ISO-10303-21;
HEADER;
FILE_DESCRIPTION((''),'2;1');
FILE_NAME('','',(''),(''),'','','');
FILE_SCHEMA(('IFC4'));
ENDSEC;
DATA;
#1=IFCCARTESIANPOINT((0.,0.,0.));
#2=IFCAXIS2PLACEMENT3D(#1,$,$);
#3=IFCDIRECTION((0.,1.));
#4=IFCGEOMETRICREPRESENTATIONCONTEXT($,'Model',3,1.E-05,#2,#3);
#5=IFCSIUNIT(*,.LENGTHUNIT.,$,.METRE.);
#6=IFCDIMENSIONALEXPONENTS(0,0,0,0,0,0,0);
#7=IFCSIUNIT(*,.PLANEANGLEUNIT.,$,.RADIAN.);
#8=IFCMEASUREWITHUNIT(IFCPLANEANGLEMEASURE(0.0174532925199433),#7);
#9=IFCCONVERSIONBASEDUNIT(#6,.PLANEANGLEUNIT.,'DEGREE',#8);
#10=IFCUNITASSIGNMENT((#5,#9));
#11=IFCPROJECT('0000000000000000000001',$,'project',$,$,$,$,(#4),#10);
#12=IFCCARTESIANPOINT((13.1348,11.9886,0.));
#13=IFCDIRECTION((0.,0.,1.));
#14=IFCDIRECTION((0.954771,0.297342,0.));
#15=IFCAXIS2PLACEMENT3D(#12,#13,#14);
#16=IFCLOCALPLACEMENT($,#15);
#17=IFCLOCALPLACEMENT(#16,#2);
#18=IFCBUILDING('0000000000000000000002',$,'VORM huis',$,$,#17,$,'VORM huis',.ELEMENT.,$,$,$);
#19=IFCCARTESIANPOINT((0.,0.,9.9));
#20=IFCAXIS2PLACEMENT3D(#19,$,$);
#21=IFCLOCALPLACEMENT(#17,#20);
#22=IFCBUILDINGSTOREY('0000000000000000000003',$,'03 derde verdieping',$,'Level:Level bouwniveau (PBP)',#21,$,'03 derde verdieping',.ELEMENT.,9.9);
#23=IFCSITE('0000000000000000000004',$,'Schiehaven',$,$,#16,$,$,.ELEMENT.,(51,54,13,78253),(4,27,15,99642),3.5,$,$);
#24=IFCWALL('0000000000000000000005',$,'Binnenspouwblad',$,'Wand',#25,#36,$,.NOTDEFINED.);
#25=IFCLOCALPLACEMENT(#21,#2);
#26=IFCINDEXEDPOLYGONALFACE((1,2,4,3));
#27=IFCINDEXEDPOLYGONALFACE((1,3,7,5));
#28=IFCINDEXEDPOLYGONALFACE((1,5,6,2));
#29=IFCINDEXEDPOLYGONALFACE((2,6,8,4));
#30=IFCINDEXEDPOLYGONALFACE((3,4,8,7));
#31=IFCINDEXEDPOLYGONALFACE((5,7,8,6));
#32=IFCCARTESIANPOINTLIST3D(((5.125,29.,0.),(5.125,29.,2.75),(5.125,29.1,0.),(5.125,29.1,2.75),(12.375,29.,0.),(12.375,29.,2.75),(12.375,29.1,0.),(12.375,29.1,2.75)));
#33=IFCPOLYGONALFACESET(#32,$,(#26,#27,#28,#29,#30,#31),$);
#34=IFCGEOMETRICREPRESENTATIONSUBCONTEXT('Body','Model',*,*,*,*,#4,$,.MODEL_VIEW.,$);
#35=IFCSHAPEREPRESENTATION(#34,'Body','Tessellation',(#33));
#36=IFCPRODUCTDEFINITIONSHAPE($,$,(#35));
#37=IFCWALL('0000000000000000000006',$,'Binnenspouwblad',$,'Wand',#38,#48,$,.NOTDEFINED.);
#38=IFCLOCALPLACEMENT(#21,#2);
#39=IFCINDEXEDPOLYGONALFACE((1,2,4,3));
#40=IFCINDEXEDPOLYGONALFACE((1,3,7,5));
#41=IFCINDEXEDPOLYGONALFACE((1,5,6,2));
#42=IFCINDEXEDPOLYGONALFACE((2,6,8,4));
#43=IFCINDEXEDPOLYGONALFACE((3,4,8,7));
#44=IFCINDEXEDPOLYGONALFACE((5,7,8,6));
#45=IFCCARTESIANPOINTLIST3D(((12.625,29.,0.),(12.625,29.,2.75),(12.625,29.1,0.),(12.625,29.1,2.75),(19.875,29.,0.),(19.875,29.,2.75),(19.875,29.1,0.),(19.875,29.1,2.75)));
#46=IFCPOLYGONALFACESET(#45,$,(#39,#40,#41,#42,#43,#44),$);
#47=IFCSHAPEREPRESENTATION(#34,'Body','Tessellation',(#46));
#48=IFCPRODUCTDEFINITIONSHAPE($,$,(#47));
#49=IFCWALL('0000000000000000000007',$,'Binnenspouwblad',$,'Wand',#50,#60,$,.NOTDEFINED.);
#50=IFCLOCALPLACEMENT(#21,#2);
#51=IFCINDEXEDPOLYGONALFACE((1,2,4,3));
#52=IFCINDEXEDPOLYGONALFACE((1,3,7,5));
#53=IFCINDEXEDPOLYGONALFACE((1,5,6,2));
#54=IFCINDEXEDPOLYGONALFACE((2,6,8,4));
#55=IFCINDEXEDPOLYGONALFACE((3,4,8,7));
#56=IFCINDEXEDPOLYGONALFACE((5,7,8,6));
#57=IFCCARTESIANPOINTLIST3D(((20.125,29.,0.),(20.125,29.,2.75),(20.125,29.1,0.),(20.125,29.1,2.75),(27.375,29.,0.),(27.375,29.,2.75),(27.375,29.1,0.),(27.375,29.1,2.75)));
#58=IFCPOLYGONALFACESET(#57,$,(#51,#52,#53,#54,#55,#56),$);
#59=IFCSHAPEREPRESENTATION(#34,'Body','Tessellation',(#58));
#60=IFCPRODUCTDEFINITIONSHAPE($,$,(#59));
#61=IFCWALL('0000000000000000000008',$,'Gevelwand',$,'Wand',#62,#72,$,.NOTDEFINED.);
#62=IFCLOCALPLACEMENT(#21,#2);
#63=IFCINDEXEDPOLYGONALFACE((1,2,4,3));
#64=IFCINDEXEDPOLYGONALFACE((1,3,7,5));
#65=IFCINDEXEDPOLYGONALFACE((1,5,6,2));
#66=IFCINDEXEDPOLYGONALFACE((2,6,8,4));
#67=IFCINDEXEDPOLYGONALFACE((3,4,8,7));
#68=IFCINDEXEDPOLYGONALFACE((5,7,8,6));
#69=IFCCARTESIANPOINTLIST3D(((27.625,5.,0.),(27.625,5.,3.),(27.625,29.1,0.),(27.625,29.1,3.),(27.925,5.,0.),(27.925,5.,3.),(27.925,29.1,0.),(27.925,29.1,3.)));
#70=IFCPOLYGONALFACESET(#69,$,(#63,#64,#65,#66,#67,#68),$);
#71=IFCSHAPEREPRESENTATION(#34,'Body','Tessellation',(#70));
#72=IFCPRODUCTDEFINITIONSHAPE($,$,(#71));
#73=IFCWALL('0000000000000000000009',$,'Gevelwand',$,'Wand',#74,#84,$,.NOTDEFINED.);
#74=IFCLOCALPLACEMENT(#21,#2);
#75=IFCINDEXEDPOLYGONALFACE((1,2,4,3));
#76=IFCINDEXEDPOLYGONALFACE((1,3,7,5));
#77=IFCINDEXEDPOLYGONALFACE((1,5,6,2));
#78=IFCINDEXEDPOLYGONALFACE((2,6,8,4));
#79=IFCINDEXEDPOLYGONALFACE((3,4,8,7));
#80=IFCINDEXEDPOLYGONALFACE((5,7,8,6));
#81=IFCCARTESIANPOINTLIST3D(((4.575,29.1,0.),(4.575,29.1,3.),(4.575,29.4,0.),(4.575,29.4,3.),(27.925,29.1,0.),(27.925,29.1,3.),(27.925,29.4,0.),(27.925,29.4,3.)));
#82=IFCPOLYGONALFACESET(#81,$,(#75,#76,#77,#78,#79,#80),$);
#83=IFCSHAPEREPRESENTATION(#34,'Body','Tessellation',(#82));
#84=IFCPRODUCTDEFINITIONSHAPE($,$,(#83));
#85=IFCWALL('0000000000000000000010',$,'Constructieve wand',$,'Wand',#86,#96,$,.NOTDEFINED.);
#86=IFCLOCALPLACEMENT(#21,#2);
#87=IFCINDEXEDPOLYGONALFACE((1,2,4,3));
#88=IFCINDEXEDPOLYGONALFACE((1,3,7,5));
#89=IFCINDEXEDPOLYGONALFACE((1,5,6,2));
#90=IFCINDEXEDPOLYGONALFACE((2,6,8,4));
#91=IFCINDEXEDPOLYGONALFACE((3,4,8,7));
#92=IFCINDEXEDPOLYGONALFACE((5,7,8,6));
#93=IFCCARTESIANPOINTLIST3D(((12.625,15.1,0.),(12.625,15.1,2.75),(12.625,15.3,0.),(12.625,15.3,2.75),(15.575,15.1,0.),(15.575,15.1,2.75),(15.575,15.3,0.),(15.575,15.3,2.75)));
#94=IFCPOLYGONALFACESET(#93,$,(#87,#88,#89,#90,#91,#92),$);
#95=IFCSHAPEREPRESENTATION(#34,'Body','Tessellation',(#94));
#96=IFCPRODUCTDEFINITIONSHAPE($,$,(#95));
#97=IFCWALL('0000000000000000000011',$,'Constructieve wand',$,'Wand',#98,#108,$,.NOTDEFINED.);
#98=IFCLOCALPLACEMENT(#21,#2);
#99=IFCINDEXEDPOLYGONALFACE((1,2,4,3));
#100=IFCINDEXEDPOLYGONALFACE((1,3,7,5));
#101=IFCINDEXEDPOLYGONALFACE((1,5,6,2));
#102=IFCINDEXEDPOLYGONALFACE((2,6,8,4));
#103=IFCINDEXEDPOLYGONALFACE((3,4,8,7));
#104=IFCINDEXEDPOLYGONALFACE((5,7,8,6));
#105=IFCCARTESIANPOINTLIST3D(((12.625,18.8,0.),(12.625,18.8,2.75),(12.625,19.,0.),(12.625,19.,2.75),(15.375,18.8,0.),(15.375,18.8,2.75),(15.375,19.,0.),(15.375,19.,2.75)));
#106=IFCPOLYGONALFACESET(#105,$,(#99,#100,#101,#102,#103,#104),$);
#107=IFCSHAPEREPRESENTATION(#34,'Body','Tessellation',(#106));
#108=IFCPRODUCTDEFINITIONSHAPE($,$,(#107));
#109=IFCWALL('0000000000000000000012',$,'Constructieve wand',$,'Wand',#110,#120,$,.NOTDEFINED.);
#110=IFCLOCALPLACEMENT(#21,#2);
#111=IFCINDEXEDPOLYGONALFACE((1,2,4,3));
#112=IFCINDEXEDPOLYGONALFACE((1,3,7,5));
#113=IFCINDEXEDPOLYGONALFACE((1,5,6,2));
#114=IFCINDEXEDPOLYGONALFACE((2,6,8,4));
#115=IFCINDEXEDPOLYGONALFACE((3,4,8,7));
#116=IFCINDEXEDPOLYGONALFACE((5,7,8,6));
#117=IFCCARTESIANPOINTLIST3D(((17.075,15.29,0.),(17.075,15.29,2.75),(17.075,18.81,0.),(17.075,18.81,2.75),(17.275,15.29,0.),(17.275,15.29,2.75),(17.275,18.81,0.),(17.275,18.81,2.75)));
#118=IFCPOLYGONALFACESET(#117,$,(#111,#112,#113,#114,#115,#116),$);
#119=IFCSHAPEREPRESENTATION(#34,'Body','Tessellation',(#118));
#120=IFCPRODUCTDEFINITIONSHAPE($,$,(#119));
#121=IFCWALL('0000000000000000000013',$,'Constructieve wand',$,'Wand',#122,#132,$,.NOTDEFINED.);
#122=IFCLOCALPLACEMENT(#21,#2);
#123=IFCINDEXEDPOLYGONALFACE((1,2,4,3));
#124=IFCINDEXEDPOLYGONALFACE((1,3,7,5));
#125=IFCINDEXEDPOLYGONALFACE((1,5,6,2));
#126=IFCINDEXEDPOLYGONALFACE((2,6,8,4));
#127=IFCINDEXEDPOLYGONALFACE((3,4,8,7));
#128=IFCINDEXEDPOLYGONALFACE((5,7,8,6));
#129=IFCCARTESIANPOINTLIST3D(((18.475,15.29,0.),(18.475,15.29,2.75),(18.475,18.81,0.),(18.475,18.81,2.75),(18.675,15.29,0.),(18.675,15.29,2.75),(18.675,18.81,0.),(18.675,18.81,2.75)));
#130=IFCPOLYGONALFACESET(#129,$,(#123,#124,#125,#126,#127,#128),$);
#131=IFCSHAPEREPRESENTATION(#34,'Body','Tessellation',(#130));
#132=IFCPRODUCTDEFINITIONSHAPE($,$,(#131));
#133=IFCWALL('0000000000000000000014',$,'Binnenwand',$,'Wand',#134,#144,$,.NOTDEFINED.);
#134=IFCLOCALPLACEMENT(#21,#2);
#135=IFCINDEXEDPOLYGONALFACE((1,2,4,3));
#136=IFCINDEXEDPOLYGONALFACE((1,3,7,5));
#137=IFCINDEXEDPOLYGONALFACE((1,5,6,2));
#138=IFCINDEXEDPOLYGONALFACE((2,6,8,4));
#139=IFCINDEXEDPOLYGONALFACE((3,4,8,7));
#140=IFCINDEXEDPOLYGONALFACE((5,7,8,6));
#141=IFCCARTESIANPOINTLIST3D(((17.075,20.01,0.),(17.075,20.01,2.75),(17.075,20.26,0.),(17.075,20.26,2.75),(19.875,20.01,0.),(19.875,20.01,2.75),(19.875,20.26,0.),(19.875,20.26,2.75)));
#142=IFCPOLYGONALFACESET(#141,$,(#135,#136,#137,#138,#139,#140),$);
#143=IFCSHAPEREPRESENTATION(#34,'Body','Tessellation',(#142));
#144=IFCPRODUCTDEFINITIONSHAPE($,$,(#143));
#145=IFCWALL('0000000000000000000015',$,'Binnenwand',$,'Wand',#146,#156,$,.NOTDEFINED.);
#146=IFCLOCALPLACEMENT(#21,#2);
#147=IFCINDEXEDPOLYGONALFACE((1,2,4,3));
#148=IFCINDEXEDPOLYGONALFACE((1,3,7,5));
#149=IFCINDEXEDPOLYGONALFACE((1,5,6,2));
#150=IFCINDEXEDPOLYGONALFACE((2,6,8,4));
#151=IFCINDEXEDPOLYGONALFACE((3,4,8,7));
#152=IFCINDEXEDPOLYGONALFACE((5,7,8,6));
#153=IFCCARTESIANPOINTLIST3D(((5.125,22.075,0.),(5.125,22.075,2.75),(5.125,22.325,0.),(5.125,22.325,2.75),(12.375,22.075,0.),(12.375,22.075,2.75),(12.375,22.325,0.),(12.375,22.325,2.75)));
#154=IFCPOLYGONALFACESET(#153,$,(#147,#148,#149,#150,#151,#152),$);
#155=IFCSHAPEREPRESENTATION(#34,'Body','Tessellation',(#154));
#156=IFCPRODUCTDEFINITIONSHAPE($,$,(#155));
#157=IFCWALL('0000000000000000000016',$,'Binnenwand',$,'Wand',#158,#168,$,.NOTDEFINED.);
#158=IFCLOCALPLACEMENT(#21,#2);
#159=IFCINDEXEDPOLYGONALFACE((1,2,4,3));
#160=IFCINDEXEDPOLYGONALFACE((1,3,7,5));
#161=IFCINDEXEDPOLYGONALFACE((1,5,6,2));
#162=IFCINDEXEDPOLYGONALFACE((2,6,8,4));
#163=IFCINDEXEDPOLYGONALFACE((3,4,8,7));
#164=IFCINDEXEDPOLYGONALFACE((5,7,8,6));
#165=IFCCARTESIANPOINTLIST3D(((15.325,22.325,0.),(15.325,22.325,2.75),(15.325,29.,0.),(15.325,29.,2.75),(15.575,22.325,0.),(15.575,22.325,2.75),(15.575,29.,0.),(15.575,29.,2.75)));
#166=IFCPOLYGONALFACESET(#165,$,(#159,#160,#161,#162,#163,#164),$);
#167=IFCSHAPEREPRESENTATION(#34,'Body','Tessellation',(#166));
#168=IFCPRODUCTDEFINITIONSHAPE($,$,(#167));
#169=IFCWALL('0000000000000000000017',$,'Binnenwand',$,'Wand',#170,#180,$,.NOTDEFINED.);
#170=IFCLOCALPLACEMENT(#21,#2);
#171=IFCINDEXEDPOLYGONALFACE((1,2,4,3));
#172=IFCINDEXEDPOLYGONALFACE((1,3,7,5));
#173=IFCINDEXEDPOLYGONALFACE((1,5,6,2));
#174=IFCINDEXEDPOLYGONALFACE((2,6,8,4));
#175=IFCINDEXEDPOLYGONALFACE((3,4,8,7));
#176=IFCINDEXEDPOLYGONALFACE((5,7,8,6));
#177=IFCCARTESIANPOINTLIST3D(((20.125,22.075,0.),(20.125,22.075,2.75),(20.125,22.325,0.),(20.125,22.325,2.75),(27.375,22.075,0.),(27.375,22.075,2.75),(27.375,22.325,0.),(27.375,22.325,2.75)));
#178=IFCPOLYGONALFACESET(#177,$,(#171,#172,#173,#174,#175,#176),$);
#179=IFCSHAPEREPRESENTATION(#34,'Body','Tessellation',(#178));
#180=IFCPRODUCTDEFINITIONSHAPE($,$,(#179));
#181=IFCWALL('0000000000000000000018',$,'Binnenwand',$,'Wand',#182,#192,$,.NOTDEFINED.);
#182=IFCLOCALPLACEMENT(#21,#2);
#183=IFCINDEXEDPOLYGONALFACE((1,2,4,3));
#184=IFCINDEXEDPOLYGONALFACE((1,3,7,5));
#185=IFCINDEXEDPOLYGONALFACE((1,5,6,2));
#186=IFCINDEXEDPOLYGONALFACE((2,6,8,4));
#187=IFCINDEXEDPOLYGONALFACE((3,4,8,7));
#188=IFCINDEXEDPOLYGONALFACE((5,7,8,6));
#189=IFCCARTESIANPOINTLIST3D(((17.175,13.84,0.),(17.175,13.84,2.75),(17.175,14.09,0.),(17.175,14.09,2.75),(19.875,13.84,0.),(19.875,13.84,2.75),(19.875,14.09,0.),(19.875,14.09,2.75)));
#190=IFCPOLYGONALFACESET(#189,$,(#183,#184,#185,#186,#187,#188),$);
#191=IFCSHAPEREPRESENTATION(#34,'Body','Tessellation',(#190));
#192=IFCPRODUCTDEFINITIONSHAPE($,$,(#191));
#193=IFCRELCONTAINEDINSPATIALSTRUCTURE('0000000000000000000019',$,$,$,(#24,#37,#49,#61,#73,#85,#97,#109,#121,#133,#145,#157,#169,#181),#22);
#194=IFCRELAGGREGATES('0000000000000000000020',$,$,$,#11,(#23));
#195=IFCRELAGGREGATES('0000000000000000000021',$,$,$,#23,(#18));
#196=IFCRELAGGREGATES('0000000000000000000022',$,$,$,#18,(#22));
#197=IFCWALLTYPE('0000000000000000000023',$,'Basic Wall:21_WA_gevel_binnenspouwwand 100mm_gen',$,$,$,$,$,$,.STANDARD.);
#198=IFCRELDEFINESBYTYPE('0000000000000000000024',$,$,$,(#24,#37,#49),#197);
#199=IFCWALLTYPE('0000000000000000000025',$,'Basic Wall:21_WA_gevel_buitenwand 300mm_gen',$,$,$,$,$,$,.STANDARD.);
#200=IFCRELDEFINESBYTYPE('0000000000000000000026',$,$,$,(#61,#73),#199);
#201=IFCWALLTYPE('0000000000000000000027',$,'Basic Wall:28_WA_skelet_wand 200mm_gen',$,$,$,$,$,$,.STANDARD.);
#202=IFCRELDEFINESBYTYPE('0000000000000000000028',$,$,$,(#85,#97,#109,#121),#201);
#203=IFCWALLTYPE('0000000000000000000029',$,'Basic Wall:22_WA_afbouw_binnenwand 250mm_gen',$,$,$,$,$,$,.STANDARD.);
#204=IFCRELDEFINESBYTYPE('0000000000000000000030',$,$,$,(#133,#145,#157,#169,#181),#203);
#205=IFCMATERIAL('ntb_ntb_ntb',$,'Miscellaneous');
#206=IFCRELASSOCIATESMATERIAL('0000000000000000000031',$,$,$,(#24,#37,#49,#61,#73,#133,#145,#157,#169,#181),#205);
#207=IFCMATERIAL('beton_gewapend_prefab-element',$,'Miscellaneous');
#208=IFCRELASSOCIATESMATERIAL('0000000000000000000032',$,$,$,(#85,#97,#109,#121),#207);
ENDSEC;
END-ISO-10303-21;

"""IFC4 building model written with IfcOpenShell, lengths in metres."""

from ifc_helpers import new_model, entity, si_unit, converted_unit, direction, frame, origin, place, context, subcontext, project, spatial, indexed_curve, outline, extrude, material, type_object, element, save


model = new_model("IFC4")

# Units and contexts
model_context = context("Model", 3, precision=1e-05, world=origin(), true_north=direction((0.0, 1.0)))
body_context = subcontext(model_context, "Body", "Model", "MODEL_VIEW")
ifc_project = project(units=[si_unit("LENGTHUNIT", "METRE"), converted_unit("PLANEANGLEUNIT", "DEGREE", entity("IfcPlaneAngleMeasure", 0.0174532925199433), si_unit("PLANEANGLEUNIT", "RADIAN"), dimensions=[0, 0, 0, 0, 0, 0, 0])], contexts=[model_context])

# Site, building, storey
site_placement = place(None, frame((13.1348, 11.9886, 0.0), z_axis=(0.0, 0.0, 1.0), x_axis=(0.954771, 0.297342, 0.0)))
site = spatial("IfcSite", under=ifc_project, at=site_placement, Name="Schiehaven", CompositionType="ELEMENT", RefLatitude=(51, 54, 13, 78253), RefLongitude=(4, 27, 15, 99642), RefElevation=3.5)
building_placement = place(site_placement, origin())
building = spatial("IfcBuilding", under=site, at=building_placement, Name="VORM huis", LongName="VORM huis", CompositionType="ELEMENT")
storey_placement = place(building_placement, frame((0.0, 0.0, 9.9)))
storey = spatial("IfcBuildingStorey", under=building, at=storey_placement, Name="03 derde verdieping", ObjectType="Level:Level bouwniveau (PBP)", LongName="03 derde verdieping", CompositionType="ELEMENT", Elevation=9.9)

# Walls
ifc_material_1 = material(Name="ntb_ntb_ntb", Category="Miscellaneous")
wall_type_1 = type_object("IfcWallType", Name="Basic Wall:21_WA_gevel_binnenspouwwand 100mm_gen", PredefinedType="STANDARD")
wall_1_placement = place(storey_placement, frame((5.125, 29.05, 0.0)))
element("IfcWall", 1, at=wall_1_placement, inside=storey, type_object=wall_type_1, material=ifc_material_1, Name="Binnenspouwblad", ObjectType="Wand", PredefinedType="NOTDEFINED", context=body_context, shape_type="SweptSolid", body=[
    extrude(outline(indexed_curve([(7.25, 0.05), (0.0, 0.05), (0.0, -0.05), (7.25, -0.05), (7.25, 0.05)], self_intersect=False)), origin(), (0.0, 0.0, 1.0), 2.75),
])
wall_2_placement = place(storey_placement, frame((19.875, 29.05, 0.0), z_axis=(0.0, 0.0, 1.0), x_axis=(-1.0, 0.0, 0.0)))
element("IfcWall", 2, at=wall_2_placement, inside=storey, type_object=wall_type_1, material=ifc_material_1, Name="Binnenspouwblad", ObjectType="Wand", PredefinedType="NOTDEFINED", context=body_context, shape_type="SweptSolid", body=[
    extrude(outline(indexed_curve([(7.25, 0.05), (0.0, 0.05), (0.0, -0.05), (7.25, -0.05), (7.25, 0.05)], self_intersect=False)), origin(), (0.0, 0.0, 1.0), 2.75),
])
wall_3_placement = place(storey_placement, frame((20.125, 29.05, 0.0)))
element("IfcWall", 3, at=wall_3_placement, inside=storey, type_object=wall_type_1, material=ifc_material_1, Name="Binnenspouwblad", ObjectType="Wand", PredefinedType="NOTDEFINED", context=body_context, shape_type="SweptSolid", body=[
    extrude(outline(indexed_curve([(7.25, 0.05), (0.0, 0.05), (0.0, -0.05), (7.25, -0.05), (7.25, 0.05)], self_intersect=False)), origin(), (0.0, 0.0, 1.0), 2.75),
])
wall_type_2 = type_object("IfcWallType", Name="Basic Wall:21_WA_gevel_buitenwand 300mm_gen", PredefinedType="STANDARD")
wall_4_placement = place(storey_placement, frame((27.775, 29.1, 0.0), z_axis=(0.0, 0.0, 1.0), x_axis=(0.0, -1.0, 0.0)))
element("IfcWall", 4, at=wall_4_placement, inside=storey, type_object=wall_type_2, material=ifc_material_1, Name="Gevelwand", ObjectType="Wand", PredefinedType="NOTDEFINED", context=body_context, shape_type="SweptSolid", body=[
    extrude(outline(indexed_curve([(24.1, 0.15), (0.0, 0.15), (0.0, -0.15), (24.1, -0.15), (24.1, 0.15)], self_intersect=False)), origin(), (0.0, 0.0, 1.0), 3.0),
])
wall_5_placement = place(storey_placement, frame((4.575, 29.25, 0.0)))
element("IfcWall", 5, at=wall_5_placement, inside=storey, type_object=wall_type_2, material=ifc_material_1, Name="Gevelwand", ObjectType="Wand", PredefinedType="NOTDEFINED", context=body_context, shape_type="SweptSolid", body=[
    extrude(outline(indexed_curve([(23.35, 0.15), (0.0, 0.15), (0.0, -0.15), (23.35, -0.15), (23.35, 0.15)], self_intersect=False)), origin(), (0.0, 0.0, 1.0), 3.0),
])
ifc_material_2 = material(Name="beton_gewapend_prefab-element", Category="Miscellaneous")
wall_type_3 = type_object("IfcWallType", Name="Basic Wall:28_WA_skelet_wand 200mm_gen", PredefinedType="STANDARD")
wall_6_placement = place(storey_placement, frame((12.625, 15.2, 0.0)))
element("IfcWall", 6, at=wall_6_placement, inside=storey, type_object=wall_type_3, material=ifc_material_2, Name="Constructieve wand", ObjectType="Wand", PredefinedType="NOTDEFINED", context=body_context, shape_type="SweptSolid", body=[
    extrude(outline(indexed_curve([(2.95, 0.1), (0.0, 0.1), (0.0, -0.1), (2.95, -0.1), (2.95, 0.1)], self_intersect=False)), origin(), (0.0, 0.0, 1.0), 2.75),
])
wall_7_placement = place(storey_placement, frame((15.375, 18.9, 0.0), z_axis=(0.0, 0.0, 1.0), x_axis=(-1.0, 0.0, 0.0)))
element("IfcWall", 7, at=wall_7_placement, inside=storey, type_object=wall_type_3, material=ifc_material_2, Name="Constructieve wand", ObjectType="Wand", PredefinedType="NOTDEFINED", context=body_context, shape_type="SweptSolid", body=[
    extrude(outline(indexed_curve([(2.75, 0.1), (0.0, 0.1), (0.0, -0.1), (2.75, -0.1), (2.75, 0.1)], self_intersect=False)), origin(), (0.0, 0.0, 1.0), 2.75),
])
wall_8_placement = place(storey_placement, frame((17.175, 15.29, 0.0), z_axis=(0.0, 0.0, 1.0), x_axis=(0.0, 1.0, 0.0)))
element("IfcWall", 8, at=wall_8_placement, inside=storey, type_object=wall_type_3, material=ifc_material_2, Name="Constructieve wand", ObjectType="Wand", PredefinedType="NOTDEFINED", context=body_context, shape_type="SweptSolid", body=[
    extrude(outline(indexed_curve([(3.52, 0.1), (0.0, 0.1), (0.0, -0.1), (3.52, -0.1), (3.52, 0.1)], self_intersect=False)), origin(), (0.0, 0.0, 1.0), 2.75),
])
wall_9_placement = place(storey_placement, frame((18.575, 15.29, 0.0), z_axis=(0.0, 0.0, 1.0), x_axis=(0.0, 1.0, 0.0)))
element("IfcWall", 9, at=wall_9_placement, inside=storey, type_object=wall_type_3, material=ifc_material_2, Name="Constructieve wand", ObjectType="Wand", PredefinedType="NOTDEFINED", context=body_context, shape_type="SweptSolid", body=[
    extrude(outline(indexed_curve([(3.52, 0.1), (0.0, 0.1), (0.0, -0.1), (3.52, -0.1), (3.52, 0.1)], self_intersect=False)), origin(), (0.0, 0.0, 1.0), 2.75),
])
wall_type_4 = type_object("IfcWallType", Name="Basic Wall:22_WA_afbouw_binnenwand 250mm_gen", PredefinedType="STANDARD")
wall_10_placement = place(storey_placement, frame((19.875, 20.135, 0.0), z_axis=(0.0, 0.0, 1.0), x_axis=(-1.0, 0.0, 0.0)))
element("IfcWall", 10, at=wall_10_placement, inside=storey, type_object=wall_type_4, material=ifc_material_1, Name="Binnenwand", ObjectType="Wand", PredefinedType="NOTDEFINED", context=body_context, shape_type="SweptSolid", body=[
    extrude(outline(indexed_curve([(2.8, 0.125), (0.0, 0.125), (0.0, -0.125), (2.8, -0.125), (2.8, 0.125)], self_intersect=False)), origin(), (0.0, 0.0, 1.0), 2.75),
])
wall_11_placement = place(storey_placement, frame((12.375, 22.2, 0.0), z_axis=(0.0, 0.0, 1.0), x_axis=(-1.0, 0.0, 0.0)))
element("IfcWall", 11, at=wall_11_placement, inside=storey, type_object=wall_type_4, material=ifc_material_1, Name="Binnenwand", ObjectType="Wand", PredefinedType="NOTDEFINED", context=body_context, shape_type="SweptSolid", body=[
    extrude(outline(indexed_curve([(7.25, 0.125), (0.0, 0.125), (0.0, -0.125), (7.25, -0.125), (7.25, 0.125)], self_intersect=False)), origin(), (0.0, 0.0, 1.0), 2.75),
])
wall_12_placement = place(storey_placement, frame((15.45, 22.325, 0.0), z_axis=(0.0, 0.0, 1.0), x_axis=(0.0, 1.0, 0.0)))
element("IfcWall", 12, at=wall_12_placement, inside=storey, type_object=wall_type_4, material=ifc_material_1, Name="Binnenwand", ObjectType="Wand", PredefinedType="NOTDEFINED", context=body_context, shape_type="SweptSolid", body=[
    extrude(outline(indexed_curve([(6.675, 0.125), (0.0, 0.125), (0.0, -0.125), (6.675, -0.125), (6.675, 0.125)], self_intersect=False)), origin(), (0.0, 0.0, 1.0), 2.75),
])
wall_13_placement = place(storey_placement, frame((20.125, 22.2, 0.0)))
element("IfcWall", 13, at=wall_13_placement, inside=storey, type_object=wall_type_4, material=ifc_material_1, Name="Binnenwand", ObjectType="Wand", PredefinedType="NOTDEFINED", context=body_context, shape_type="SweptSolid", body=[
    extrude(outline(indexed_curve([(7.25, 0.125), (0.0, 0.125), (0.0, -0.125), (7.25, -0.125), (7.25, 0.125)], self_intersect=False)), origin(), (0.0, 0.0, 1.0), 2.75),
])
wall_14_placement = place(storey_placement, frame((19.875, 13.965, 0.0), z_axis=(0.0, 0.0, 1.0), x_axis=(-1.0, 0.0, 0.0)))
element("IfcWall", 14, at=wall_14_placement, inside=storey, type_object=wall_type_4, material=ifc_material_1, Name="Binnenwand", ObjectType="Wand", PredefinedType="NOTDEFINED", context=body_context, shape_type="SweptSolid", body=[
    extrude(outline(indexed_curve([(2.7, 0.125), (0.0, 0.125), (0.0, -0.125), (2.7, -0.125), (2.7, 0.125)], self_intersect=False)), origin(), (0.0, 0.0, 1.0), 2.75),
])

save(model, "model.ifc")
